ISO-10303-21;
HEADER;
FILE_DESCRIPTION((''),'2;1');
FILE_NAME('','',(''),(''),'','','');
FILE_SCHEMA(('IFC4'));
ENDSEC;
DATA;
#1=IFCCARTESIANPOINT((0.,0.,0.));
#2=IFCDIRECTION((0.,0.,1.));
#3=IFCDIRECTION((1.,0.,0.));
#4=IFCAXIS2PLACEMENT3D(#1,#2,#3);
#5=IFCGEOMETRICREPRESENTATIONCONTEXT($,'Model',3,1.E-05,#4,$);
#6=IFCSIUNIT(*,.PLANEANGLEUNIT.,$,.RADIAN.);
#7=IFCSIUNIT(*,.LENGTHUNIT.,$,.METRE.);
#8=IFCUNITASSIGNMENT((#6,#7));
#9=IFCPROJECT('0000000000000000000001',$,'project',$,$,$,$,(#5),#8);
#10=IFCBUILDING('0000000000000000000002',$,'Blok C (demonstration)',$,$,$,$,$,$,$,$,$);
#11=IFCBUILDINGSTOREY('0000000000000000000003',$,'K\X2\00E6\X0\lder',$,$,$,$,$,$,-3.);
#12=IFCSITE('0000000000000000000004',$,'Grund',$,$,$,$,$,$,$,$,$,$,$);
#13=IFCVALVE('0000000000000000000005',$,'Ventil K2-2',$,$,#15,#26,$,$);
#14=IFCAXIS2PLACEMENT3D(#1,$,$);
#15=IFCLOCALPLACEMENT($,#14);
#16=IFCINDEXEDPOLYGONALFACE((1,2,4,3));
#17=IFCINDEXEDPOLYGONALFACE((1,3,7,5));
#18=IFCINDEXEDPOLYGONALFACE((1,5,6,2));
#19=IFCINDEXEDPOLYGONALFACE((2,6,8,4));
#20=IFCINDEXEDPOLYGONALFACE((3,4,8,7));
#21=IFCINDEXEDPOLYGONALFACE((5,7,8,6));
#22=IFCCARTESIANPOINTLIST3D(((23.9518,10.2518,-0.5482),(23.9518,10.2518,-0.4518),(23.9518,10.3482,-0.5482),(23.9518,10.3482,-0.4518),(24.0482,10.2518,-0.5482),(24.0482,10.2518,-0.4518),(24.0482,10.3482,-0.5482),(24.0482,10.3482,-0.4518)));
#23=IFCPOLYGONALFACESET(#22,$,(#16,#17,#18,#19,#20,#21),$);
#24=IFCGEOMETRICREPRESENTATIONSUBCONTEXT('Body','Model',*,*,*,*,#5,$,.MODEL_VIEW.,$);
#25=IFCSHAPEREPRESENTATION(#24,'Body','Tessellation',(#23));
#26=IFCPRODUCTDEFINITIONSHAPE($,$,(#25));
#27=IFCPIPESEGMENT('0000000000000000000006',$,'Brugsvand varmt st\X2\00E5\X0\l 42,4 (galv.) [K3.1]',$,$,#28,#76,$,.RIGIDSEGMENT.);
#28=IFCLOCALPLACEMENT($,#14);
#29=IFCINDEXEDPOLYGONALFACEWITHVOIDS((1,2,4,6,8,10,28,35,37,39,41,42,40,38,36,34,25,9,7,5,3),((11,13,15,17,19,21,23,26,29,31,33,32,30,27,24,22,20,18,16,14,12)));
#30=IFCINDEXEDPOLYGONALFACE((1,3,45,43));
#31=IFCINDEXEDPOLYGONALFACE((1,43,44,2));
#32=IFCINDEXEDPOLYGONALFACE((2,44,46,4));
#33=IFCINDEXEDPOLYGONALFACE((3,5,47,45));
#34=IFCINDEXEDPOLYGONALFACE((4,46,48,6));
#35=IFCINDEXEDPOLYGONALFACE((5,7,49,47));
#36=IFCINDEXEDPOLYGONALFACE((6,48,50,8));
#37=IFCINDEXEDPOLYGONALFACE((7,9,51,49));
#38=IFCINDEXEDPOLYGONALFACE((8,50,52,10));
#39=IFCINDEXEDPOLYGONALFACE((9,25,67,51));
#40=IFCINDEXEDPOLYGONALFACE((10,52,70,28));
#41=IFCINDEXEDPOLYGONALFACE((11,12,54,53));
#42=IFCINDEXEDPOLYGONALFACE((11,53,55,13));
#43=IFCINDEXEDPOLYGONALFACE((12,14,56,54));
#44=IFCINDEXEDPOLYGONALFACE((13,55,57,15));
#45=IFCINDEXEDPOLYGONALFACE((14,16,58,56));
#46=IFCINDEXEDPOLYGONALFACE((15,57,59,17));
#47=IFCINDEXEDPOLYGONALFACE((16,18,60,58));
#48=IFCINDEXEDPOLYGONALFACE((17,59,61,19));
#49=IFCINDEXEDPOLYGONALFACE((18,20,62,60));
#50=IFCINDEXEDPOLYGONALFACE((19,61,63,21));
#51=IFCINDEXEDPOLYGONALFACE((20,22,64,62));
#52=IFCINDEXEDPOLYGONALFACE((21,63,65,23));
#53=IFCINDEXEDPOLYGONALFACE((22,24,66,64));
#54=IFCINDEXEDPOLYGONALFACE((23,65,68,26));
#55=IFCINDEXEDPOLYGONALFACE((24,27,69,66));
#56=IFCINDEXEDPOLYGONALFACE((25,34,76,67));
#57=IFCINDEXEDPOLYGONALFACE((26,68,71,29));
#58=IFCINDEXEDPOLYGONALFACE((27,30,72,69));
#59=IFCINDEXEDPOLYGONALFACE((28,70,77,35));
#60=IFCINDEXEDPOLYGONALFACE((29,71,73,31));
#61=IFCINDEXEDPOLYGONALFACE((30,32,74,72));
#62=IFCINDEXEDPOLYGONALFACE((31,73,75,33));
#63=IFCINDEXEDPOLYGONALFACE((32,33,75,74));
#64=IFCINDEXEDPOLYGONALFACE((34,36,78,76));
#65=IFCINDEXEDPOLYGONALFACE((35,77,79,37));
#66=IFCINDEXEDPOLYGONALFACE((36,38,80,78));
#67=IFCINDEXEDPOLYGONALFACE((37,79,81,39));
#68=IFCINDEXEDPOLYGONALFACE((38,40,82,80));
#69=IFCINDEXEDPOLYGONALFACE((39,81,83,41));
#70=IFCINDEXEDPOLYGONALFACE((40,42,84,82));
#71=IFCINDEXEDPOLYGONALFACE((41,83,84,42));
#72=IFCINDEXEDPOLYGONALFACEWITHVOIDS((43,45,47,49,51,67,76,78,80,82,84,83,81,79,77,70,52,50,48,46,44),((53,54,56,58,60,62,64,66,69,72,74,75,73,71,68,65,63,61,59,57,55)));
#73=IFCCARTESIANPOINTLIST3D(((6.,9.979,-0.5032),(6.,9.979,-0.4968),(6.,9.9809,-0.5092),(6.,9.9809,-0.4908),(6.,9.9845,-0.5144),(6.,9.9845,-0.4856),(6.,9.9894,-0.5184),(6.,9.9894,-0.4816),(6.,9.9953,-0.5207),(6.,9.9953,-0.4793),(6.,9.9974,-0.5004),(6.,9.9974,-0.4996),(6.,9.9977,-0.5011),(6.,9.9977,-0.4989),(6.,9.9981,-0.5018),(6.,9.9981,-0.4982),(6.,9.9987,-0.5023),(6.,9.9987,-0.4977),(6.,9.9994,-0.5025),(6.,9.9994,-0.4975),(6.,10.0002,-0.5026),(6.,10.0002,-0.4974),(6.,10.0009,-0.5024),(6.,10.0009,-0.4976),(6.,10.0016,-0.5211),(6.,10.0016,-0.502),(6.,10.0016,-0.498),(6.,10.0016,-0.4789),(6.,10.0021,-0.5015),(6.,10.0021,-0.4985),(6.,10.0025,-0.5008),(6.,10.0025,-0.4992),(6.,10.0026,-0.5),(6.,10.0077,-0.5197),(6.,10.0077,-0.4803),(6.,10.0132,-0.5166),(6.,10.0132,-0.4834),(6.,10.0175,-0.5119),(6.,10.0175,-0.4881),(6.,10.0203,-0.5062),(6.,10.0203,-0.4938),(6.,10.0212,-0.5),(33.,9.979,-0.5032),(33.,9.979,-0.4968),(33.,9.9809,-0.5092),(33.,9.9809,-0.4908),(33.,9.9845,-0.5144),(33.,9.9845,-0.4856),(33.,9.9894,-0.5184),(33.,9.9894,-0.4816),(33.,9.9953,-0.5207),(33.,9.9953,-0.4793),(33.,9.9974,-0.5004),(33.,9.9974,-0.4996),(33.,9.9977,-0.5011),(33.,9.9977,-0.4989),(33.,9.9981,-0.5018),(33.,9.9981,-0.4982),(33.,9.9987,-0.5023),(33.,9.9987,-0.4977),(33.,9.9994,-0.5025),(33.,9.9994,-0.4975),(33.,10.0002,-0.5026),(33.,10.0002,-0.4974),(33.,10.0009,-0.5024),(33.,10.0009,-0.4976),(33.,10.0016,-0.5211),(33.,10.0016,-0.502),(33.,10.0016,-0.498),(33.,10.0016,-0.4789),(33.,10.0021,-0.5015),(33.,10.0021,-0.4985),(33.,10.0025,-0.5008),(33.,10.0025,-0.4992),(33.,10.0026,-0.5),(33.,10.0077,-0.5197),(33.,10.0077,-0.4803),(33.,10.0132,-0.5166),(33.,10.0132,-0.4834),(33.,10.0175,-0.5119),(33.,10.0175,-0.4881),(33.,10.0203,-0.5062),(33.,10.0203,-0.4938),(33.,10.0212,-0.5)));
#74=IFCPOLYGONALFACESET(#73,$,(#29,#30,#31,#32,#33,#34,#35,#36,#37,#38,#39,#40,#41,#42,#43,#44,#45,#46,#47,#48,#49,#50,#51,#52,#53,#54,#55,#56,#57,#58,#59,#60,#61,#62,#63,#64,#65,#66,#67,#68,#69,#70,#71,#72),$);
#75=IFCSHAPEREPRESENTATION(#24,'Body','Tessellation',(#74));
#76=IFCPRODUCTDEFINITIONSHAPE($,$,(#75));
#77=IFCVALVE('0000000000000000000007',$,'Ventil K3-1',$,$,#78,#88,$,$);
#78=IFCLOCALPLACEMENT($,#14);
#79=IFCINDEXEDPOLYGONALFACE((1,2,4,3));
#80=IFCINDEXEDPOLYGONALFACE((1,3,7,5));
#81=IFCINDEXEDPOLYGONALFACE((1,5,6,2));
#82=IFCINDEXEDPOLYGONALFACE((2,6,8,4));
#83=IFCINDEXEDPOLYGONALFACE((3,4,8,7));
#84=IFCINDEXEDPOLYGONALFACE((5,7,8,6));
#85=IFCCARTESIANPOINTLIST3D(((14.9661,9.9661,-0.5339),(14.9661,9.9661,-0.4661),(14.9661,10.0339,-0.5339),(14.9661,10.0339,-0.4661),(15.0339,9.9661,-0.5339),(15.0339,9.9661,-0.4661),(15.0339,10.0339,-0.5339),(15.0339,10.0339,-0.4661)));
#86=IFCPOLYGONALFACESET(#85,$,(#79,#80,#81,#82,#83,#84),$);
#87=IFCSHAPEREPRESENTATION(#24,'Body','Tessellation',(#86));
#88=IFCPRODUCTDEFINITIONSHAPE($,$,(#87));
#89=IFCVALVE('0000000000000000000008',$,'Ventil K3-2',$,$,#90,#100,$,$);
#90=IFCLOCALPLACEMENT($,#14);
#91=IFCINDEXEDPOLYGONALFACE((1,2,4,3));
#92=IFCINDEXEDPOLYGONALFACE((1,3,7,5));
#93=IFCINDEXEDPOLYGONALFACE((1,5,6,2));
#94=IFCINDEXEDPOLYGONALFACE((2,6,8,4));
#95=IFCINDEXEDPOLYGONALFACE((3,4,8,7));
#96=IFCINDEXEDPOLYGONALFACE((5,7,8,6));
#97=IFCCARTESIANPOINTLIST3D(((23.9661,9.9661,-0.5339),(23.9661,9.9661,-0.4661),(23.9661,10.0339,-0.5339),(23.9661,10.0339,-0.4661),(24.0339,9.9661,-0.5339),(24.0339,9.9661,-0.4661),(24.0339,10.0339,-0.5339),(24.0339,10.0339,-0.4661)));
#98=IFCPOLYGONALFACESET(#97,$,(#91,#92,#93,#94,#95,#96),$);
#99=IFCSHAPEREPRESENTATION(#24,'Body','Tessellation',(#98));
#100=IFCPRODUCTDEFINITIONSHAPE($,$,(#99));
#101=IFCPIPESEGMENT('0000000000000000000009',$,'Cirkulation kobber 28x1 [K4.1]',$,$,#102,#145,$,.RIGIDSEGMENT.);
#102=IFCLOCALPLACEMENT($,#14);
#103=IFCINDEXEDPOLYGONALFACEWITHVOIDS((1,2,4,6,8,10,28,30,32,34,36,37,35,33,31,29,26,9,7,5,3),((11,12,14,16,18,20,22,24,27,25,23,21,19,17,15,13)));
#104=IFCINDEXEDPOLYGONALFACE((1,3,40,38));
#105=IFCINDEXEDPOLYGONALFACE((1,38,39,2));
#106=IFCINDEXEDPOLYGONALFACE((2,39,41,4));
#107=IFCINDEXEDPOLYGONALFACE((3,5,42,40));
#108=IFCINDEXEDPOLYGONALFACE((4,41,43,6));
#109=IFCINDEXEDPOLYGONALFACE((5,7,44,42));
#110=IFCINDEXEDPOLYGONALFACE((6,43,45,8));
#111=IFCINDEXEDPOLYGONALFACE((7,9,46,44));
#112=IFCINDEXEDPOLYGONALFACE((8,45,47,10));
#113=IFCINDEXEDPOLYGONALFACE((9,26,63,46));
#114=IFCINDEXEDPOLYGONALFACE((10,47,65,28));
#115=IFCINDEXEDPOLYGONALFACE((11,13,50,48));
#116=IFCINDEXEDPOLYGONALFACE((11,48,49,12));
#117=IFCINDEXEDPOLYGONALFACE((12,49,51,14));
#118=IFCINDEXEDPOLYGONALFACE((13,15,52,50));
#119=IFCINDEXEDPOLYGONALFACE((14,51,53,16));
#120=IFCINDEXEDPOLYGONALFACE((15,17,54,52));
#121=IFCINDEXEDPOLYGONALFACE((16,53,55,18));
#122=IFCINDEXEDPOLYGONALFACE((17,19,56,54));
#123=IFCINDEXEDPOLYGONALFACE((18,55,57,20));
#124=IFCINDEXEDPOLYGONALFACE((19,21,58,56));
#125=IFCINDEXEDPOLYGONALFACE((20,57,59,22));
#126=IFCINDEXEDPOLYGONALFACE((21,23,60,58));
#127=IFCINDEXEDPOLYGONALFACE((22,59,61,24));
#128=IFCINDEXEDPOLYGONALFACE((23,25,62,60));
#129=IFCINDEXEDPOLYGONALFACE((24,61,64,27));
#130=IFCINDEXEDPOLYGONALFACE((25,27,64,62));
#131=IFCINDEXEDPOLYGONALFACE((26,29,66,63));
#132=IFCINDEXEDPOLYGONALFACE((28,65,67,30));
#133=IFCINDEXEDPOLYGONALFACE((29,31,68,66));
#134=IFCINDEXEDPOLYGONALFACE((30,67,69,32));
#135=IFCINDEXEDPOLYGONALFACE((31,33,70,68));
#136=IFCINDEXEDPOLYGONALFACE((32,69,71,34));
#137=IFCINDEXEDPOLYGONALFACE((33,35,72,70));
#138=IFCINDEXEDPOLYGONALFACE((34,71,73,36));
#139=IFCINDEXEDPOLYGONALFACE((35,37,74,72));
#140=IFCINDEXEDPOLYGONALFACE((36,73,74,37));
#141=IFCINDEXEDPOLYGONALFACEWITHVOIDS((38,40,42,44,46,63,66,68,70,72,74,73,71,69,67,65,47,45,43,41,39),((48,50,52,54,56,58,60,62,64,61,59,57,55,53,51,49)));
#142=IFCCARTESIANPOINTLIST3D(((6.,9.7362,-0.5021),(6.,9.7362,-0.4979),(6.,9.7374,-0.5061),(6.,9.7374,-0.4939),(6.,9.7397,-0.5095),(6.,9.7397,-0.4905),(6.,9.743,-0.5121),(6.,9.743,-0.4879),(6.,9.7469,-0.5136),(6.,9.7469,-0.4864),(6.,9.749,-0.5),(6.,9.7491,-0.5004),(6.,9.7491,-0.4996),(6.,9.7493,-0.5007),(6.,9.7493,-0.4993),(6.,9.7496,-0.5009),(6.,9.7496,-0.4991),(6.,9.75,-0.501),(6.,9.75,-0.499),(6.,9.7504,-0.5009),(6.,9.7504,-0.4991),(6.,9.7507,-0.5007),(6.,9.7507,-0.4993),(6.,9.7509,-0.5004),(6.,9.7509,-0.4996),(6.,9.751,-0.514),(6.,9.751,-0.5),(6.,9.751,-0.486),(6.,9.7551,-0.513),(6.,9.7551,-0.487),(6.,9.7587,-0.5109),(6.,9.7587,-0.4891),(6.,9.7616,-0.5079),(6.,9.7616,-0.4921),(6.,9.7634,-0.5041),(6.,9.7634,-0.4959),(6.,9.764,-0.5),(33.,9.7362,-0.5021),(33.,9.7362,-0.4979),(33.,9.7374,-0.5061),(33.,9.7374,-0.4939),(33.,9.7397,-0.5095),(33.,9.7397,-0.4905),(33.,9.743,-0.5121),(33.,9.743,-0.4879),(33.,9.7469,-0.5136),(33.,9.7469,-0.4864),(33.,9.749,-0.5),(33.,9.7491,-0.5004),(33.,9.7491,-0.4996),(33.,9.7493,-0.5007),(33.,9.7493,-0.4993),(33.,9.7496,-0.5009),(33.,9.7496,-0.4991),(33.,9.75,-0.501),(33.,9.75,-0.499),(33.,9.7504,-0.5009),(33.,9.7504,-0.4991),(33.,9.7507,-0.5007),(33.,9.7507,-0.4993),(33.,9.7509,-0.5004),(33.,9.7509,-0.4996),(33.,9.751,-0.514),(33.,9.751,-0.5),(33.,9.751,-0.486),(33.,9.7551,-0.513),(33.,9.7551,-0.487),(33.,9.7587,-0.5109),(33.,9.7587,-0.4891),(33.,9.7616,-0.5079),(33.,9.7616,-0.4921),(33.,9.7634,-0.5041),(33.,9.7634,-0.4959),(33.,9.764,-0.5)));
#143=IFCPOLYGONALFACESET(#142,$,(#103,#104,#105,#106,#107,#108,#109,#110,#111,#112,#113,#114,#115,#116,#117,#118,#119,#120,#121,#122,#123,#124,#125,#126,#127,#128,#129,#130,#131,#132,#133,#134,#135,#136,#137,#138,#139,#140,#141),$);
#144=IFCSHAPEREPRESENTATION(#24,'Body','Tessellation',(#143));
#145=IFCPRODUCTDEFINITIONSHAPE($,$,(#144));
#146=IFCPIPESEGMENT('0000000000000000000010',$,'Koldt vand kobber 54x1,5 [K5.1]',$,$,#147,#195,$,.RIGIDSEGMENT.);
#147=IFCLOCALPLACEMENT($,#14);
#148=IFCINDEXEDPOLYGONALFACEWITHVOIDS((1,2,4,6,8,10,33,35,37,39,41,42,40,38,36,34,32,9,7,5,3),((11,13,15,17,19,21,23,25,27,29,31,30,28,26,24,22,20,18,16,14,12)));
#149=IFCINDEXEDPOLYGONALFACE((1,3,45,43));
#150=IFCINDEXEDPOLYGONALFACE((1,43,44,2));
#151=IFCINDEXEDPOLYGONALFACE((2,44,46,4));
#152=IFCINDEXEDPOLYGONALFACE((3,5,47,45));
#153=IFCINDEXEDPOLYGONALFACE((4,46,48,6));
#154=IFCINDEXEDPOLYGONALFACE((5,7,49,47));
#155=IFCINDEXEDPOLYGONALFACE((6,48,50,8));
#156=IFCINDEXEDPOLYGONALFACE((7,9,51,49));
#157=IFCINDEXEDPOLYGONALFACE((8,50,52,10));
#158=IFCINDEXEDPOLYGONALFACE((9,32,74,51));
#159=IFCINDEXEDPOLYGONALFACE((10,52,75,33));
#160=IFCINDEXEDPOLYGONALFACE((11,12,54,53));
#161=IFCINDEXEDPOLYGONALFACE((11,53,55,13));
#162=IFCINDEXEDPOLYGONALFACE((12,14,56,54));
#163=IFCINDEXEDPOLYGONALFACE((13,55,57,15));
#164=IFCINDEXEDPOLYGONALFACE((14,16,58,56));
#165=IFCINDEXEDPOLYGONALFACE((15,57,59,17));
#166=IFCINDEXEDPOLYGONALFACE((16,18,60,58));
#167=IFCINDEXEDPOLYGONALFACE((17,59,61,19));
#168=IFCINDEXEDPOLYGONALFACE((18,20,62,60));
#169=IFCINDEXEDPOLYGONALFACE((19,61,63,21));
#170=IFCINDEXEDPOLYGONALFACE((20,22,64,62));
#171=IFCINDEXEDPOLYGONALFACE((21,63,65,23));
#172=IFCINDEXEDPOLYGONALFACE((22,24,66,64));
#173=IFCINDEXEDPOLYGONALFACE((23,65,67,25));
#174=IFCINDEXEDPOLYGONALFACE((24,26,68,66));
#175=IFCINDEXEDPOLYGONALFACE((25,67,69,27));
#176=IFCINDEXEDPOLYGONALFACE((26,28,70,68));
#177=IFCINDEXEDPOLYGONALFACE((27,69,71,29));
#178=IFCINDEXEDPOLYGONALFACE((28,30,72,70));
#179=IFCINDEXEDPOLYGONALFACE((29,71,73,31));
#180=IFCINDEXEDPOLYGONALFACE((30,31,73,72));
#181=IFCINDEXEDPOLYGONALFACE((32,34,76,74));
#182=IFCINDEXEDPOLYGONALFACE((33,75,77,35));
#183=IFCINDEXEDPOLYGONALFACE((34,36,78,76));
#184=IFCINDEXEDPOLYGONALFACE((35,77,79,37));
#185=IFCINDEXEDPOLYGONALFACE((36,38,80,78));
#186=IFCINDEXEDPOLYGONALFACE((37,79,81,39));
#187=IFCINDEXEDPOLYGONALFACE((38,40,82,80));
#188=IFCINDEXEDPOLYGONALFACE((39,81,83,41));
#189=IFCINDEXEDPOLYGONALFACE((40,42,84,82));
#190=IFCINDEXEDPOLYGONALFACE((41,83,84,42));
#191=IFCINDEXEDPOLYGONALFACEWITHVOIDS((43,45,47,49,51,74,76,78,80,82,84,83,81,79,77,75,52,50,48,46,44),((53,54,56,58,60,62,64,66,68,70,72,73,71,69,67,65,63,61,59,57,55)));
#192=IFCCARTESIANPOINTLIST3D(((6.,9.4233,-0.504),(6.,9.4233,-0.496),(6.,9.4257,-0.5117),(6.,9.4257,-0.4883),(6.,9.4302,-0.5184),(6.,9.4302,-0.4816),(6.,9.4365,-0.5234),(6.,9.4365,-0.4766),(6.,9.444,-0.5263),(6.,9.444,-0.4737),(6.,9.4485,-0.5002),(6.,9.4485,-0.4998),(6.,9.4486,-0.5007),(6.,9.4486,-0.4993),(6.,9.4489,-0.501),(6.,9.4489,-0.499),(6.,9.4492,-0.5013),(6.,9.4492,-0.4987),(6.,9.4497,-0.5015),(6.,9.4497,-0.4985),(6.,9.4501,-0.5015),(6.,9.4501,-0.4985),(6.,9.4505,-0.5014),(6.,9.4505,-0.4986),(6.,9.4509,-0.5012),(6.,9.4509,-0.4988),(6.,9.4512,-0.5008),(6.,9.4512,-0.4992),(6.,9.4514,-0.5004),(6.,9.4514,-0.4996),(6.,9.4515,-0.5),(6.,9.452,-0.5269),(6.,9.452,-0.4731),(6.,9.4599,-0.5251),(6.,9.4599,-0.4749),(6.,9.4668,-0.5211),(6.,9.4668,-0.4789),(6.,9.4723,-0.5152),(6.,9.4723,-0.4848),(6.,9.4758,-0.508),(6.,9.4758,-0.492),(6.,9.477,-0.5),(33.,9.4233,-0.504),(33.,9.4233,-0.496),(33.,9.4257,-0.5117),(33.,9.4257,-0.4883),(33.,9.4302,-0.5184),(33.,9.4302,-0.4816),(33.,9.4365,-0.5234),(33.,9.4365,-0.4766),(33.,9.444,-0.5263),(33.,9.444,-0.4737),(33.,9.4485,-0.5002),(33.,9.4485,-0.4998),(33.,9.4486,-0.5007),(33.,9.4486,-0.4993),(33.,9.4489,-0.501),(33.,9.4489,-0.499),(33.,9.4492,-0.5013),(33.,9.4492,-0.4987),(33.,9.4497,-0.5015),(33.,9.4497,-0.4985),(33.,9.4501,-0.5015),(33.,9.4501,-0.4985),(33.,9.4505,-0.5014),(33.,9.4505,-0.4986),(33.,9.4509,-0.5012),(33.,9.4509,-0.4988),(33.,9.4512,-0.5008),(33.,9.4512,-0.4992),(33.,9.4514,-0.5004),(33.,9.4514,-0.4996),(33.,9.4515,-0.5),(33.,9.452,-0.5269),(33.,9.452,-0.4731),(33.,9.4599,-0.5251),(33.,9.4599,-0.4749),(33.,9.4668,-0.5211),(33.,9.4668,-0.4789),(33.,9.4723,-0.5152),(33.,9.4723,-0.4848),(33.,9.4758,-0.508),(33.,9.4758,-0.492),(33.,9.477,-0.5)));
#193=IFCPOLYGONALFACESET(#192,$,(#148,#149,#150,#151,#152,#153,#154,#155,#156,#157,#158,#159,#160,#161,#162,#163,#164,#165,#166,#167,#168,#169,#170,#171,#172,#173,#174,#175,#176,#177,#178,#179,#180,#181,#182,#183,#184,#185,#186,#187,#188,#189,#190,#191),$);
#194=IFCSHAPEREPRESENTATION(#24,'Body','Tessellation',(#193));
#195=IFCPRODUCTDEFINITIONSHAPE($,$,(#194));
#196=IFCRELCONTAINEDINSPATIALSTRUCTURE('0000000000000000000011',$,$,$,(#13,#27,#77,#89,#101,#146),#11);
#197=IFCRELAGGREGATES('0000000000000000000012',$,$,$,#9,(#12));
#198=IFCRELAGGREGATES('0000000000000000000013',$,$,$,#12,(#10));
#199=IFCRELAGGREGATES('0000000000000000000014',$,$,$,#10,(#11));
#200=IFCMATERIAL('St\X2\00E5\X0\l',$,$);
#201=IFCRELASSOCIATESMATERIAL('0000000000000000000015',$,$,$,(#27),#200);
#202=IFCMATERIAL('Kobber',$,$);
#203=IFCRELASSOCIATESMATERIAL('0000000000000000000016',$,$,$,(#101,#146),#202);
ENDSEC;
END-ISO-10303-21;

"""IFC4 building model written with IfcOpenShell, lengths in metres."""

from ifc_helpers import new_model, si_unit, frame, origin_with_axes, place, context, subcontext, project, spatial, polyline, hollow_circle, outline, extrude, material, element, save


model = new_model("IFC4")

# Units and contexts
model_context = context("Model", 3, precision=1e-05, world=origin_with_axes())
body_context = subcontext(model_context, "Body", "Model", "MODEL_VIEW")
ifc_project = project(units=[si_unit("PLANEANGLEUNIT", "RADIAN"), si_unit("LENGTHUNIT", "METRE")], contexts=[model_context])

# Site, building, storey
site = spatial("IfcSite", under=ifc_project, Name="Grund")
building = spatial("IfcBuilding", under=site, Name="Blok C (demonstration)")
storey = spatial("IfcBuildingStorey", under=building, Name="Kælder", Elevation=-3.0)

# Shared definitions
ifc_material_1 = material(Name="Stål")

# Valve
valve_1_placement = place(None, origin_with_axes())
element("IfcValve", 1, at=valve_1_placement, inside=storey, Name="Ventil K2-2", context=body_context, shape_type="SweptSolid", body=[
    extrude(outline(polyline([(23.9518, 10.2518), (24.0482, 10.2518), (24.0482, 10.3482), (23.9518, 10.3482), (23.9518, 10.2518)])), frame((0.0, 0.0, -0.5482)), (0.0, 0.0, 1.0), 0.0965),
])

# Pipe segment
pipe_segment_1_placement = place(None, origin_with_axes())
element("IfcPipeSegment", 2, at=pipe_segment_1_placement, inside=storey, material=ifc_material_1, Name="Brugsvand varmt stål 42,4 (galv.) [K3.1]", PredefinedType="RIGIDSEGMENT", context=body_context, shape_type="SweptSolid", body=[
    extrude(hollow_circle(Radius=0.0212, WallThickness=0.0186), frame((6.0, 10.0, -0.5), z_axis=(1.0, 0.0, 0.0), x_axis=(0.0, 1.0, 0.0)), (0.0, 0.0, 1.0), 27.0),
])

# Valves
valve_2_placement = place(None, origin_with_axes())
element("IfcValve", 3, at=valve_2_placement, inside=storey, Name="Ventil K3-1", context=body_context, shape_type="SweptSolid", body=[
    extrude(outline(polyline([(14.9661, 9.9661), (15.0339, 9.9661), (15.0339, 10.0339), (14.9661, 10.0339), (14.9661, 9.9661)])), frame((0.0, 0.0, -0.5339)), (0.0, 0.0, 1.0), 0.0678),
])
valve_3_placement = place(None, origin_with_axes())
element("IfcValve", 4, at=valve_3_placement, inside=storey, Name="Ventil K3-2", context=body_context, shape_type="SweptSolid", body=[
    extrude(outline(polyline([(23.9661, 9.9661), (24.0339, 9.9661), (24.0339, 10.0339), (23.9661, 10.0339), (23.9661, 9.9661)])), frame((0.0, 0.0, -0.5339)), (0.0, 0.0, 1.0), 0.0678),
])

# Pipe segments
ifc_material_2 = material(Name="Kobber")
pipe_segment_2_placement = place(None, origin_with_axes())
element("IfcPipeSegment", 5, at=pipe_segment_2_placement, inside=storey, material=ifc_material_2, Name="Cirkulation kobber 28x1 [K4.1]", PredefinedType="RIGIDSEGMENT", context=body_context, shape_type="SweptSolid", body=[
    extrude(hollow_circle(Radius=0.014, WallThickness=0.013), frame((6.0, 9.75, -0.5), z_axis=(1.0, 0.0, 0.0), x_axis=(0.0, 1.0, 0.0)), (0.0, 0.0, 1.0), 27.0),
])
pipe_segment_3_placement = place(None, origin_with_axes())
element("IfcPipeSegment", 6, at=pipe_segment_3_placement, inside=storey, material=ifc_material_2, Name="Koldt vand kobber 54x1,5 [K5.1]", PredefinedType="RIGIDSEGMENT", context=body_context, shape_type="SweptSolid", body=[
    extrude(hollow_circle(Radius=0.027, WallThickness=0.0255), frame((6.0, 9.45, -0.5), z_axis=(1.0, 0.0, 0.0), x_axis=(0.0, 1.0, 0.0)), (0.0, 0.0, 1.0), 27.0),
])

save(model, "model.ifc")
